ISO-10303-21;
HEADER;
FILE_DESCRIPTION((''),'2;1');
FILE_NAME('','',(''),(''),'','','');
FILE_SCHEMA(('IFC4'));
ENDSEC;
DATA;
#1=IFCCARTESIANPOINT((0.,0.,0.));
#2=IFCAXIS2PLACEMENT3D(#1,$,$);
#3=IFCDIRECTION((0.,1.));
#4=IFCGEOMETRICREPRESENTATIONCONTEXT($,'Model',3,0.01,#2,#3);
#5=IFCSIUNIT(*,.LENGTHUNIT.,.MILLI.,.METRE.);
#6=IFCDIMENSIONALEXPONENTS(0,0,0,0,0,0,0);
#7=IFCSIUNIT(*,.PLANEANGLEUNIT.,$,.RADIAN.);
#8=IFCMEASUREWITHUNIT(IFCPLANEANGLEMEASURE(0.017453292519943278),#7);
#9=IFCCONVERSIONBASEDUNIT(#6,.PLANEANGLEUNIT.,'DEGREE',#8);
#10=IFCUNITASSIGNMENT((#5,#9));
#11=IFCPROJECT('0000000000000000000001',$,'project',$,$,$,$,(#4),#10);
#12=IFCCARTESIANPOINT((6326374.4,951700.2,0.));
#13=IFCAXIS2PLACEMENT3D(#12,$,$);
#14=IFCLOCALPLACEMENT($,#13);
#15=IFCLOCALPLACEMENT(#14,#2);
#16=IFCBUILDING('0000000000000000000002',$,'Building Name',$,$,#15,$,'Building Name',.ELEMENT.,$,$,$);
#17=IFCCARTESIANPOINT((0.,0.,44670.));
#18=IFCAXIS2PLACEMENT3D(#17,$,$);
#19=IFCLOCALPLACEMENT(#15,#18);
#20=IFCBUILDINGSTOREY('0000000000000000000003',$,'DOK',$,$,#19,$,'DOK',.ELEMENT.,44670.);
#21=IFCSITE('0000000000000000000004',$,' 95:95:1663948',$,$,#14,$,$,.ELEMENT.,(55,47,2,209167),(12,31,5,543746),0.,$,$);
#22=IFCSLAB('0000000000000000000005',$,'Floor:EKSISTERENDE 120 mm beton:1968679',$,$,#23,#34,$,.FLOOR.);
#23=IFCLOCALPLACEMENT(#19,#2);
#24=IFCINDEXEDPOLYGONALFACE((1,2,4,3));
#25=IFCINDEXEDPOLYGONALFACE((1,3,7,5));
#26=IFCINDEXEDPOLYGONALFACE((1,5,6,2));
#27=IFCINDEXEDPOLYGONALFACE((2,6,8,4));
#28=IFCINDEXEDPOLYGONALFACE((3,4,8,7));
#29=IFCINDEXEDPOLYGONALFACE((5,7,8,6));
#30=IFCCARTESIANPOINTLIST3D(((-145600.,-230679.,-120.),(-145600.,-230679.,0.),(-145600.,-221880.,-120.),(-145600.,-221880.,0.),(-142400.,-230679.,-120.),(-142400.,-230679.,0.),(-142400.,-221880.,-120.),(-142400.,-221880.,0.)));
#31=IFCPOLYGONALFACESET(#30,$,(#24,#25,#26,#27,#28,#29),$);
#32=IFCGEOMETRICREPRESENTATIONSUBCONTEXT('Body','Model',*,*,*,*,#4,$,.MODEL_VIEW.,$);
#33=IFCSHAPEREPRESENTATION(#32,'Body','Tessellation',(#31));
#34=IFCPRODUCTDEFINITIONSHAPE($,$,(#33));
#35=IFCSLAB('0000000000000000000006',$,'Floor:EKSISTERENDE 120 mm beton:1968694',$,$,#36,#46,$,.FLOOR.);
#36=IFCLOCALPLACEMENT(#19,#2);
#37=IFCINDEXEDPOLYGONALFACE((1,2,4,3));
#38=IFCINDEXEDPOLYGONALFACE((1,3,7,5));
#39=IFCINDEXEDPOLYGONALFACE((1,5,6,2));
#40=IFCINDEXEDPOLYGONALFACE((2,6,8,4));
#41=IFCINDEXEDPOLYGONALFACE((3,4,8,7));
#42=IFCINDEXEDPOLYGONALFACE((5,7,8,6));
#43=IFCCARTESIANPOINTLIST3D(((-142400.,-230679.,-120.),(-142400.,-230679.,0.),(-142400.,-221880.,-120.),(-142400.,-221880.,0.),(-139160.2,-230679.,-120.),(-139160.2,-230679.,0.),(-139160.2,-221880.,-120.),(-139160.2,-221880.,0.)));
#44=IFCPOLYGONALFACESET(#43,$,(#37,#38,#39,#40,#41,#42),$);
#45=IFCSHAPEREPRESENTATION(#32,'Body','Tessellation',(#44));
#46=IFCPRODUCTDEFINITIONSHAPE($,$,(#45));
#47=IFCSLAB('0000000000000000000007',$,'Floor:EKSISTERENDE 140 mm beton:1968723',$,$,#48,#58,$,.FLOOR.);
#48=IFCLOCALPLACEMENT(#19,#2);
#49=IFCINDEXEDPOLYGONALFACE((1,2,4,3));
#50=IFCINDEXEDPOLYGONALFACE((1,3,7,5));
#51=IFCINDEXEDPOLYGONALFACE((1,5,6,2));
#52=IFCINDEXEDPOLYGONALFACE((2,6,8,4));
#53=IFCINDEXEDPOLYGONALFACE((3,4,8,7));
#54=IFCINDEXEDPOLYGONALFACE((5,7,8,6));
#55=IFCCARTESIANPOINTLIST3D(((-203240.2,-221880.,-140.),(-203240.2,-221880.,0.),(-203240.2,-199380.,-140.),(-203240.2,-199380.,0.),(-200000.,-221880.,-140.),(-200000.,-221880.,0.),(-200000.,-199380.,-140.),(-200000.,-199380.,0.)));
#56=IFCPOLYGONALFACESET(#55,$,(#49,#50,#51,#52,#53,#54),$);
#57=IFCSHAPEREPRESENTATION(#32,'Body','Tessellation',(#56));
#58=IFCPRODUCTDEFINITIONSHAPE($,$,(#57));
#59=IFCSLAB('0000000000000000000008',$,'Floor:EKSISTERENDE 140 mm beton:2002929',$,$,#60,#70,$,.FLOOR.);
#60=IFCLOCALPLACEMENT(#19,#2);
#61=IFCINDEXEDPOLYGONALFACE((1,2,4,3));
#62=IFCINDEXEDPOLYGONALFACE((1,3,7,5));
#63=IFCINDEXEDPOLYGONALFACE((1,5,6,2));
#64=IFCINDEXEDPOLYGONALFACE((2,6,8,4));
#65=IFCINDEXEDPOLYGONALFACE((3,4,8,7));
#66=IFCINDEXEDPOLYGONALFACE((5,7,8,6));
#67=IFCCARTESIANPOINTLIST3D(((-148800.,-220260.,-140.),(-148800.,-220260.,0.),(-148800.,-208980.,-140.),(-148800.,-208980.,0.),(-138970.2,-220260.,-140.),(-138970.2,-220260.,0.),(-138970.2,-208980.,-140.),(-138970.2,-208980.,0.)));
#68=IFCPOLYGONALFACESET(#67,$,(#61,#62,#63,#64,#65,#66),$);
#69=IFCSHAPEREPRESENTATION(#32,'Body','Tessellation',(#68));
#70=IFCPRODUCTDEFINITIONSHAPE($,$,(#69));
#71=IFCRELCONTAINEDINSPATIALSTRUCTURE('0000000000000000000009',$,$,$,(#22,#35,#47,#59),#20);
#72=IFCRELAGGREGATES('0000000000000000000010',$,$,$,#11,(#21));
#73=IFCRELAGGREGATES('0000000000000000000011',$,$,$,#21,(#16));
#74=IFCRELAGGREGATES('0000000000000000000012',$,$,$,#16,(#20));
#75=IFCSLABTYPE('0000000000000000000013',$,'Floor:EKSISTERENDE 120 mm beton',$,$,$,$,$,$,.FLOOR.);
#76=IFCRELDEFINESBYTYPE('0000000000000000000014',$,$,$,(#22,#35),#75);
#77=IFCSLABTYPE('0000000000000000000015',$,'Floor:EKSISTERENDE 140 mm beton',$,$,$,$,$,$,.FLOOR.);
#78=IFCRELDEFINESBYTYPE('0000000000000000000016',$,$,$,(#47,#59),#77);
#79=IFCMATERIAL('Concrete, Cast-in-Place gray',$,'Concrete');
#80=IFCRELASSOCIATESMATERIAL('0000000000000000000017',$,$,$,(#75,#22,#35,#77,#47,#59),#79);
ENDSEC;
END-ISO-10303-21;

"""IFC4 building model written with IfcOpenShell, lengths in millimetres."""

from ifc_helpers import new_model, entity, si_unit, converted_unit, direction, frame, origin, place, context, subcontext, project, spatial, indexed_curve, outline, extrude, material, type_object, element, save


model = new_model("IFC4")

# Units and contexts
model_context = context("Model", 3, precision=0.01, world=origin(), true_north=direction((0.0, 1.0)))
body_context = subcontext(model_context, "Body", "Model", "MODEL_VIEW")
ifc_project = project(units=[si_unit("LENGTHUNIT", "METRE", prefix="MILLI"), converted_unit("PLANEANGLEUNIT", "DEGREE", entity("IfcPlaneAngleMeasure", 0.017453292519943278), si_unit("PLANEANGLEUNIT", "RADIAN"), dimensions=[0, 0, 0, 0, 0, 0, 0])], contexts=[model_context])

# Site, building, storey
site_placement = place(None, frame((6326374.4, 951700.2, 0.0)))
site = spatial("IfcSite", under=ifc_project, at=site_placement, Name=" 95:95:1663948", CompositionType="ELEMENT", RefLatitude=(55, 47, 2, 209167), RefLongitude=(12, 31, 5, 543746), RefElevation=0.0)
building_placement = place(site_placement, origin())
building = spatial("IfcBuilding", under=site, at=building_placement, Name="Building Name", LongName="Building Name", CompositionType="ELEMENT")
storey_placement = place(building_placement, frame((0.0, 0.0, 44670.0)))
storey = spatial("IfcBuildingStorey", under=building, at=storey_placement, Name="DOK", LongName="DOK", CompositionType="ELEMENT", Elevation=44670.0)

# Shared definitions
ifc_material = material(Name="Concrete, Cast-in-Place gray", Category="Concrete")

# Slabs
slab_type_1 = type_object("IfcSlabType", Name="Floor:EKSISTERENDE 120 mm beton", PredefinedType="FLOOR", material=ifc_material)
slab_1_placement = place(storey_placement, origin())
element("IfcSlab", 1, at=slab_1_placement, inside=storey, type_object=slab_type_1, material=ifc_material, Name="Floor:EKSISTERENDE 120 mm beton:1968679", PredefinedType="FLOOR", context=body_context, shape_type="SweptSolid", body=[
    extrude(outline(indexed_curve([(-4399.5, -1600.0), (4399.5, -1600.0), (4399.5, 1600.0), (-4399.5, 1600.0), (-4399.5, -1600.0)], self_intersect=False)), frame((-144000.0, -226279.5, 0.0), z_axis=(0.0, 0.0, -1.0), x_axis=(0.0, 1.0, 0.0)), (0.0, 0.0, 1.0), 120.0),
])
slab_2_placement = place(storey_placement, origin())
element("IfcSlab", 2, at=slab_2_placement, inside=storey, type_object=slab_type_1, material=ifc_material, Name="Floor:EKSISTERENDE 120 mm beton:1968694", PredefinedType="FLOOR", context=body_context, shape_type="SweptSolid", body=[
    extrude(outline(indexed_curve([(-4399.5, -1619.9), (4399.5, -1619.9), (4399.5, 1619.9), (-4399.5, 1619.9), (-4399.5, -1619.9)], self_intersect=False)), frame((-140780.1, -226279.5, 0.0), z_axis=(0.0, 0.0, -1.0), x_axis=(0.0, 1.0, 0.0)), (0.0, 0.0, 1.0), 120.0),
])
slab_type_2 = type_object("IfcSlabType", Name="Floor:EKSISTERENDE 140 mm beton", PredefinedType="FLOOR", material=ifc_material)
slab_3_placement = place(storey_placement, origin())
element("IfcSlab", 3, at=slab_3_placement, inside=storey, type_object=slab_type_2, material=ifc_material, Name="Floor:EKSISTERENDE 140 mm beton:1968723", PredefinedType="FLOOR", context=body_context, shape_type="SweptSolid", body=[
    extrude(outline(indexed_curve([(-11250.0, -1620.1), (11250.0, -1620.1), (11250.0, 1620.1), (-11250.0, 1620.1), (-11250.0, -1620.1)], self_intersect=False)), frame((-201620.1, -210630.0, 0.0), z_axis=(0.0, 0.0, -1.0), x_axis=(0.0, 1.0, 0.0)), (0.0, 0.0, 1.0), 140.0),
])
slab_4_placement = place(storey_placement, origin())
element("IfcSlab", 4, at=slab_4_placement, inside=storey, type_object=slab_type_2, material=ifc_material, Name="Floor:EKSISTERENDE 140 mm beton:2002929", PredefinedType="FLOOR", context=body_context, shape_type="SweptSolid", body=[
    extrude(outline(indexed_curve([(-4914.9, -5640.0), (4914.9, -5640.0), (4914.9, 5640.0), (-4914.9, 5640.0), (-4914.9, -5640.0)], self_intersect=False)), frame((-143885.1, -214620.0, 0.0), z_axis=(0.0, 0.0, -1.0), x_axis=(1.0, 0.0, 0.0)), (0.0, 0.0, 1.0), 140.0),
])

save(model, "model.ifc")
